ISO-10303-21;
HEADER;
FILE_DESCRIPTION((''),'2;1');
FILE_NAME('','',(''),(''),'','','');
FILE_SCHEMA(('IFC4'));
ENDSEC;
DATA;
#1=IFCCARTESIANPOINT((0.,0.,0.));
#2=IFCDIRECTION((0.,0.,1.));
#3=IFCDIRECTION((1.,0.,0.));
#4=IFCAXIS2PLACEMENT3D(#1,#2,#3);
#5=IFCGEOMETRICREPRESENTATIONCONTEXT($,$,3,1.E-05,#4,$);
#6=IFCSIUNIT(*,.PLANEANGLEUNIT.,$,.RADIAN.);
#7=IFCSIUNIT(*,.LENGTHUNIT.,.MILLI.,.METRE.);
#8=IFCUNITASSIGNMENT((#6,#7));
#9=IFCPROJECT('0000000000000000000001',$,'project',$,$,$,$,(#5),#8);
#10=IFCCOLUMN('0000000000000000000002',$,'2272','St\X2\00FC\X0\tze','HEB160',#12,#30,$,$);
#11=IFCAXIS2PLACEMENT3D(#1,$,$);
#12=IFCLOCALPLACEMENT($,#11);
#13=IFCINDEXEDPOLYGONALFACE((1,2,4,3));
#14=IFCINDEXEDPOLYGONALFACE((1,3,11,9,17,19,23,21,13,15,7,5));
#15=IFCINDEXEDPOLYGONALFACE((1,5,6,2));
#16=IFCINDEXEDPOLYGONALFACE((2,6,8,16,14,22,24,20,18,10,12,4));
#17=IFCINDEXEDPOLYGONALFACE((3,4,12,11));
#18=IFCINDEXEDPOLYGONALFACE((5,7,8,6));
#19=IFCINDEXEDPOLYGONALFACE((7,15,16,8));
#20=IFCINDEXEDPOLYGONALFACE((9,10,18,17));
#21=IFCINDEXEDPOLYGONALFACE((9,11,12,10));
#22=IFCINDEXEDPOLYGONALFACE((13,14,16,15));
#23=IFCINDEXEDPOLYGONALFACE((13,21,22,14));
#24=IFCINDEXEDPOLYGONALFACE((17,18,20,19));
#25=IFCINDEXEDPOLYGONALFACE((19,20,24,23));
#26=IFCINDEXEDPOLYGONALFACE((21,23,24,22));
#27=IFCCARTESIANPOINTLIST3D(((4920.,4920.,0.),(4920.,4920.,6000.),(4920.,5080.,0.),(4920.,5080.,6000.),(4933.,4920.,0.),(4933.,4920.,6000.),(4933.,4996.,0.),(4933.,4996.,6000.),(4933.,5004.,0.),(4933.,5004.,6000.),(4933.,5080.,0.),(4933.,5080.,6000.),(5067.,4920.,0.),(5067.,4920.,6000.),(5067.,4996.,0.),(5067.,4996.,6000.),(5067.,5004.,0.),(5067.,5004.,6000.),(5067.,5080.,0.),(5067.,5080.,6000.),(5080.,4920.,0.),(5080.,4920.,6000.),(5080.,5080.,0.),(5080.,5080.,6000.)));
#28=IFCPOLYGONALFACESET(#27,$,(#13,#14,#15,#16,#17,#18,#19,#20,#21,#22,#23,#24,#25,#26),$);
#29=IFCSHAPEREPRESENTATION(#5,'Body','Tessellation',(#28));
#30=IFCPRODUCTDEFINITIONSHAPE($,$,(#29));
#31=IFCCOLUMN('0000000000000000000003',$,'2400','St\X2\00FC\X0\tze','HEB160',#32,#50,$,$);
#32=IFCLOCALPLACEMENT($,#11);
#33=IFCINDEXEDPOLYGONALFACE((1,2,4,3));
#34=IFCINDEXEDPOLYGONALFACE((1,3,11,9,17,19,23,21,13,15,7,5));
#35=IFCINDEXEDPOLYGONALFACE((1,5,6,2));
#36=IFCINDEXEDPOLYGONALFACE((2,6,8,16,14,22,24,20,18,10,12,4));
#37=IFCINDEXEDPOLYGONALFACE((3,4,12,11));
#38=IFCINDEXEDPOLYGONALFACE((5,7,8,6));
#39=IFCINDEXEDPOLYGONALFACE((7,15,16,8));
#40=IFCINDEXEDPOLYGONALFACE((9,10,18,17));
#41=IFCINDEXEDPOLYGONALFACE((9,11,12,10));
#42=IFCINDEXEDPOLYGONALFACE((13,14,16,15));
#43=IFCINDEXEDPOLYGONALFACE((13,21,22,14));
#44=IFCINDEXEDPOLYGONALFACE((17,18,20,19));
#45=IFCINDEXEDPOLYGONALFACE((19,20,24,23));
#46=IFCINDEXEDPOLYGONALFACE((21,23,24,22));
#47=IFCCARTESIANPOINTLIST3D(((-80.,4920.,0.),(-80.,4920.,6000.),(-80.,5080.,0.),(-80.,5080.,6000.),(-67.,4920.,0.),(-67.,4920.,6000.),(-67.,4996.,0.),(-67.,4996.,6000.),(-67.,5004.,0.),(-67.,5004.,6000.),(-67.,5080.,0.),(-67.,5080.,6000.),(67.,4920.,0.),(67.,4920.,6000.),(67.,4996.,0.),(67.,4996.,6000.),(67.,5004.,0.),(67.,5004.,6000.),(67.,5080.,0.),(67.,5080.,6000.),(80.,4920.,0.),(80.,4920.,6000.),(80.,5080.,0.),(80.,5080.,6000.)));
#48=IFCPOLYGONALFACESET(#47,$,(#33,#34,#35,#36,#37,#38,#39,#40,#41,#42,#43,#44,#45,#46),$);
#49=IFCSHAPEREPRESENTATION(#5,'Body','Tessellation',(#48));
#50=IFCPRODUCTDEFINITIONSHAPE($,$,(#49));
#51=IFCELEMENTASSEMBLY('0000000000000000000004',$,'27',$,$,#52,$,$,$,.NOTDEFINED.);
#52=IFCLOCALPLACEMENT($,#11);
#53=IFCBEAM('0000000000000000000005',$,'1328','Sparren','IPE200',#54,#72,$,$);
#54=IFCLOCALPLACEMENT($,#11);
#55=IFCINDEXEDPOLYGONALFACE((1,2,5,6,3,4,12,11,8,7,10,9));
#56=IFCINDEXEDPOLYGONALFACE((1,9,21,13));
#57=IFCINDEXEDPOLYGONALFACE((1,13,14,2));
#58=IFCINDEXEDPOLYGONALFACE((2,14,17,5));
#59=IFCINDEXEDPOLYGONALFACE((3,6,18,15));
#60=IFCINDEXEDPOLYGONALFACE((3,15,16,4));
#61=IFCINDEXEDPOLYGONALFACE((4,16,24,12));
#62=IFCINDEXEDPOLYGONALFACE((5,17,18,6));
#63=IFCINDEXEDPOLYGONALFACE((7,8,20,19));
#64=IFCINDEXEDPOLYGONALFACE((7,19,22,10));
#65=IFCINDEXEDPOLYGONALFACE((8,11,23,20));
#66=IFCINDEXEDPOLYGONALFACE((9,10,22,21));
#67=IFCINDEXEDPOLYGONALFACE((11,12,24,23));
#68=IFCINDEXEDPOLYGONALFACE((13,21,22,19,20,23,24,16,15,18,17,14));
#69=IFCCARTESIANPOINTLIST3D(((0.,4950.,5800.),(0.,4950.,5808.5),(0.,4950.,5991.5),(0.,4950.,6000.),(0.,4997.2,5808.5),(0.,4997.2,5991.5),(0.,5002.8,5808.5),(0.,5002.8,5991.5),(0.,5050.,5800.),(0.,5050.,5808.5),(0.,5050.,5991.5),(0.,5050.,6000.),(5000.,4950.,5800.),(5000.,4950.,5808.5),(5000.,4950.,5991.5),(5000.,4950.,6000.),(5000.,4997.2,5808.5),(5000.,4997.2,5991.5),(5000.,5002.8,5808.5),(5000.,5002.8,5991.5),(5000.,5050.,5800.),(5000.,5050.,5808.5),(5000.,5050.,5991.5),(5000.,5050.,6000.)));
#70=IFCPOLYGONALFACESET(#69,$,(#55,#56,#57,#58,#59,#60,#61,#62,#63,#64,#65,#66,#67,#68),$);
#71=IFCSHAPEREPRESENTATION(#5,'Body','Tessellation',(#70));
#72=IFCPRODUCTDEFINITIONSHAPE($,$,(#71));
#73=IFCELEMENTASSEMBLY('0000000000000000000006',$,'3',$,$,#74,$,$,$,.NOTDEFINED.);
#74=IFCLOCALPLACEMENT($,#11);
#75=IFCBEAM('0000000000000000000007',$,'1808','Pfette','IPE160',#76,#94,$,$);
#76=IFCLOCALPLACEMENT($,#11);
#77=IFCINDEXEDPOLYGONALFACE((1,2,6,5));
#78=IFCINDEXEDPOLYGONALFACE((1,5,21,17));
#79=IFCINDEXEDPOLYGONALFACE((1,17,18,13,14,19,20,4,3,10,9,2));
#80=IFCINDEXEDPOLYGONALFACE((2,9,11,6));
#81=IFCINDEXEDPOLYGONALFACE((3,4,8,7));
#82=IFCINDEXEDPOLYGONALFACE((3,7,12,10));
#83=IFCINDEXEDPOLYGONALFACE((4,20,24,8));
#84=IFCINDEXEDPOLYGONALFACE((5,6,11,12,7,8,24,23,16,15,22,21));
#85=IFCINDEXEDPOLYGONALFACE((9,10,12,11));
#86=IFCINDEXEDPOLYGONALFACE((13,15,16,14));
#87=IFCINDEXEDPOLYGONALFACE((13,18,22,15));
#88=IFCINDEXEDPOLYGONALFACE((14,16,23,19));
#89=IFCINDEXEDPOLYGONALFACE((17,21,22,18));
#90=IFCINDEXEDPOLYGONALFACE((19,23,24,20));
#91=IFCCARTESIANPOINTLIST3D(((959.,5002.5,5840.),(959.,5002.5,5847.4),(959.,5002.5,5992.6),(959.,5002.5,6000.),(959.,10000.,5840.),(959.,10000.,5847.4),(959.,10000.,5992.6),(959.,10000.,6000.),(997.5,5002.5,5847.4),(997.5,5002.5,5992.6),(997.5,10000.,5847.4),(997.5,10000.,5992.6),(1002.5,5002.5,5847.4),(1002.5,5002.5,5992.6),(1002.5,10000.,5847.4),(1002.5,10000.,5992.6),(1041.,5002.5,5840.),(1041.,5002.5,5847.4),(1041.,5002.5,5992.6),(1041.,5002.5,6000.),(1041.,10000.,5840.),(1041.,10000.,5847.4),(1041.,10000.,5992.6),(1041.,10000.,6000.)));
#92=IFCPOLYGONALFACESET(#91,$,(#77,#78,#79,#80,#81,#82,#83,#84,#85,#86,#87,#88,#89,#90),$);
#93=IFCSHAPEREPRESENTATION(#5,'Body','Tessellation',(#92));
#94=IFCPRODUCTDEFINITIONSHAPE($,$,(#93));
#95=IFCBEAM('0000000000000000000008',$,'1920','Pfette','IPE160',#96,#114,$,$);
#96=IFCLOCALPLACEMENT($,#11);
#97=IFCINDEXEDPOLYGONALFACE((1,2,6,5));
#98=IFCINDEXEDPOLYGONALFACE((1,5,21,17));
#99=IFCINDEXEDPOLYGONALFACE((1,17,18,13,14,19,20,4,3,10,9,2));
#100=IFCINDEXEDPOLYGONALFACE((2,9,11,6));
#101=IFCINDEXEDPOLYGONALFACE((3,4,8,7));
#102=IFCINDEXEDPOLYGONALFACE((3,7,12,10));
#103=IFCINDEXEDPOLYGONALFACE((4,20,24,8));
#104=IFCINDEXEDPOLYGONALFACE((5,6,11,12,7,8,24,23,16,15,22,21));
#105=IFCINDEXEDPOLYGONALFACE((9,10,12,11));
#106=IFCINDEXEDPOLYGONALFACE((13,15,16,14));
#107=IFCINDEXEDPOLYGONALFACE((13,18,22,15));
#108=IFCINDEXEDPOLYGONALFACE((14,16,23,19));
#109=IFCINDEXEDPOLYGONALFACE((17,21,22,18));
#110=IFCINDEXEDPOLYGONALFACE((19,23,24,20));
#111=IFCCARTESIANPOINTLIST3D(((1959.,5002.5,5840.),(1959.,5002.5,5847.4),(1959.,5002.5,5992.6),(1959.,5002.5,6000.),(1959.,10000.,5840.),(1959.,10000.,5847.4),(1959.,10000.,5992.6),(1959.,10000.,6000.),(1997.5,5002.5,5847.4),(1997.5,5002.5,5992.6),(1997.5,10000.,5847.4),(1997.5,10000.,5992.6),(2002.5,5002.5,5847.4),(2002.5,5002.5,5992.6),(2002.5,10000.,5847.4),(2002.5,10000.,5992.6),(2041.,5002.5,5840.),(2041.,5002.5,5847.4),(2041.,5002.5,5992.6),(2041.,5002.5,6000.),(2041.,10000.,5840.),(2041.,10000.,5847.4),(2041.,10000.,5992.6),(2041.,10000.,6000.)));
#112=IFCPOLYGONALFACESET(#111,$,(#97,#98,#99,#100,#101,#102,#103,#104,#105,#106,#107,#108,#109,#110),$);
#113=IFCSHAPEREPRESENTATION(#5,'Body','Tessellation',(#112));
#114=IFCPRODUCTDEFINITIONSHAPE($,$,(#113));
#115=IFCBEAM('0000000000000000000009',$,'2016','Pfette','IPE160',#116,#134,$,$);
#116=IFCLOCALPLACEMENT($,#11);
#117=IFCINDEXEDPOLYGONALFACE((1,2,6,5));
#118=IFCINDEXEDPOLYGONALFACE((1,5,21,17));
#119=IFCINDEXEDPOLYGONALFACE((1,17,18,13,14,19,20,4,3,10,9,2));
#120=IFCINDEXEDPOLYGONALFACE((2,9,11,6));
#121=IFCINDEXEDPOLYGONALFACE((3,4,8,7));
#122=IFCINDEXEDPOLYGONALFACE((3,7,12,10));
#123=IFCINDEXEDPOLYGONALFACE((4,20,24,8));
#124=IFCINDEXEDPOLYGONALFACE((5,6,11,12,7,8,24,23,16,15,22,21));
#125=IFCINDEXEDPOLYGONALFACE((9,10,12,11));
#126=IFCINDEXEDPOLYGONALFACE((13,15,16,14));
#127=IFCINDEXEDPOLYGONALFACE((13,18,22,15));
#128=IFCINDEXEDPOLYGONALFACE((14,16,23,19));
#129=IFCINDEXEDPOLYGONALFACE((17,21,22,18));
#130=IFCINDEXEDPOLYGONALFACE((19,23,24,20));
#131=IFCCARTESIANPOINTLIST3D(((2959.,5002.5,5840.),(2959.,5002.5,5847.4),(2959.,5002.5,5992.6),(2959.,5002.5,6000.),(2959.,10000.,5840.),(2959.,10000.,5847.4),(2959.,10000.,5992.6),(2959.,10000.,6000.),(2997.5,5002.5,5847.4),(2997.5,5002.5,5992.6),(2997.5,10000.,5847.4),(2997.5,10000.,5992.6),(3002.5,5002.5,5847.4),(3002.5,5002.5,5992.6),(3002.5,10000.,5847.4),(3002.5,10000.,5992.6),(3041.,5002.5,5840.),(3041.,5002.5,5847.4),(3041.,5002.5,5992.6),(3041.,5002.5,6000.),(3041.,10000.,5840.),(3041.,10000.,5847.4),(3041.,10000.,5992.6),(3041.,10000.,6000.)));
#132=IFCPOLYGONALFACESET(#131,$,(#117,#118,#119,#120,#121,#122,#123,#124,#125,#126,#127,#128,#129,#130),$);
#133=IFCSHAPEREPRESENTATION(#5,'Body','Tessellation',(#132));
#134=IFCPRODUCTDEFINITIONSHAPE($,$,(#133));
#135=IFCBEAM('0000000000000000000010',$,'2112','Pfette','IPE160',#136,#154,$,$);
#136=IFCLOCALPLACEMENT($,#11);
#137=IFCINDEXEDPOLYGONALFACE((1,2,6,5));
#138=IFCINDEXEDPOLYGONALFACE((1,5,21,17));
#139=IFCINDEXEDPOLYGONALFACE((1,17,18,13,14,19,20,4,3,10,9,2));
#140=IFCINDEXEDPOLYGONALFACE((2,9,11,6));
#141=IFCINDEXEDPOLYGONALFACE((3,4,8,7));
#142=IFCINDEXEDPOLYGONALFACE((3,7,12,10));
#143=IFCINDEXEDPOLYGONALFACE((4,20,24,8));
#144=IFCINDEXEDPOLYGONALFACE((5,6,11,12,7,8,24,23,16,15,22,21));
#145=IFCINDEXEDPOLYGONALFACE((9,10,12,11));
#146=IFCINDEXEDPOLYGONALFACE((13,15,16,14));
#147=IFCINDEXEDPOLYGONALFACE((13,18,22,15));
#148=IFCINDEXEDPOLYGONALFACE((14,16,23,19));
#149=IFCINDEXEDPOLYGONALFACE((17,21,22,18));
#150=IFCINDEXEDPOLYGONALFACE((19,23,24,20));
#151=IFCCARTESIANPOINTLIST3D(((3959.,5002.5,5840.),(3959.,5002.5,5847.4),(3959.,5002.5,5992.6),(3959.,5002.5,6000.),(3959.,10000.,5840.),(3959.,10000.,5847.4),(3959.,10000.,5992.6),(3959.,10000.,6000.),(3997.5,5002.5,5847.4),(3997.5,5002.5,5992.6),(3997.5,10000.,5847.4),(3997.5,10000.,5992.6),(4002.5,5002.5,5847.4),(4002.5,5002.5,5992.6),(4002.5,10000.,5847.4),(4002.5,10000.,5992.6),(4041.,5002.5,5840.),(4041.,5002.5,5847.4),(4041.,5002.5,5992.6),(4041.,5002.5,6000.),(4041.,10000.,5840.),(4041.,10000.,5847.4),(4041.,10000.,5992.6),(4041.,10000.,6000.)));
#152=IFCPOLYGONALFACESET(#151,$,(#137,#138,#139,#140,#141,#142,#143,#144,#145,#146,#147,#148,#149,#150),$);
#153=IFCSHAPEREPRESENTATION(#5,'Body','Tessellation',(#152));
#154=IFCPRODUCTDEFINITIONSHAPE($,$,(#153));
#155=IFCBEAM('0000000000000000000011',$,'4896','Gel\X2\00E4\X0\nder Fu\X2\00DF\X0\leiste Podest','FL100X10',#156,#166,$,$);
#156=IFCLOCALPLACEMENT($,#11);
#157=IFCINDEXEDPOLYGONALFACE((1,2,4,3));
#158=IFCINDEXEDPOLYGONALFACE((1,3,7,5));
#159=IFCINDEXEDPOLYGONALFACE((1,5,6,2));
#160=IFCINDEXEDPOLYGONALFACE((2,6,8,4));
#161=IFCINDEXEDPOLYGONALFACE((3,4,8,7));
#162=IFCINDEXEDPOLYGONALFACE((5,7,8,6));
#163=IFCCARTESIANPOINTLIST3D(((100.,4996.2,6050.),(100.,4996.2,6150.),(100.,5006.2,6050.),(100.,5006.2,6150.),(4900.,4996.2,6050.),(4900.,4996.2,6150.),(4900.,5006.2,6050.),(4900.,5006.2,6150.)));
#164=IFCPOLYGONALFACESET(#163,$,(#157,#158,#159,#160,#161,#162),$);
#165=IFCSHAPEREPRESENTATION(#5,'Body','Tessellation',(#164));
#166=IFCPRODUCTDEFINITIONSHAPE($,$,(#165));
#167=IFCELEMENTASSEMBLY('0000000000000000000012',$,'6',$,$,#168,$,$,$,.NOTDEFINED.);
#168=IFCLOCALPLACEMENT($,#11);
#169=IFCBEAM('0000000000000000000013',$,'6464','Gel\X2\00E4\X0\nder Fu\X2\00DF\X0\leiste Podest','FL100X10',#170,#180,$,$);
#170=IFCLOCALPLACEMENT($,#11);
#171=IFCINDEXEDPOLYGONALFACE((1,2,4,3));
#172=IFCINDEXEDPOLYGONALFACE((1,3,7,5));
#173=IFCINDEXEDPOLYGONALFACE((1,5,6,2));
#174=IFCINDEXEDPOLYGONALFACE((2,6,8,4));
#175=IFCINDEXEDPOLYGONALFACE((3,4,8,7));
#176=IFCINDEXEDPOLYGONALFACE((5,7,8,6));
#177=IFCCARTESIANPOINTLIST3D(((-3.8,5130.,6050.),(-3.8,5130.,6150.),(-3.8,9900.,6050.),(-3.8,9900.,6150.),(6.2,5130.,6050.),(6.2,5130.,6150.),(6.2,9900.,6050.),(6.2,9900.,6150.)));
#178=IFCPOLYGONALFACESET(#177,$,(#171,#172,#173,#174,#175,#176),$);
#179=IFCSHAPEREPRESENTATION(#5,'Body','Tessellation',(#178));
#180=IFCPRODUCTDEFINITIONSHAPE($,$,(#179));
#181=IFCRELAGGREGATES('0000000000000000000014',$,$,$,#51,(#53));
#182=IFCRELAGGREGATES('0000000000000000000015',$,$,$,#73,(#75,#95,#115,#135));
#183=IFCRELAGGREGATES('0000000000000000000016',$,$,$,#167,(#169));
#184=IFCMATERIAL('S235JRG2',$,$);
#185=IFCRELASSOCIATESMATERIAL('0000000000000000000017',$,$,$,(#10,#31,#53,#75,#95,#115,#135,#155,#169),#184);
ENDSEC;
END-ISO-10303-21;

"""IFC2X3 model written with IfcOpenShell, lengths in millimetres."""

from ifc_helpers import new_model, si_unit, frame, origin_with_axes, place, context, project, polyline, outline, extrude, material, element, aggregate, save


model = new_model("IFC2X3")

# Units and contexts
context_of_model = context(None, 3, precision=1e-05, world=origin_with_axes())
ifc_project = project(units=[si_unit("PLANEANGLEUNIT", "RADIAN"), si_unit("LENGTHUNIT", "METRE", prefix="MILLI")], contexts=[context_of_model])

# Columns
ifc_material = material(Name="S235JRG2")
placement_1 = place(None, frame((5000.0, 5000.0, 6000.0), z_axis=(1.0, 0.0, 0.0), x_axis=(0.0, 0.0, -1.0)))
column_1_placement = place(placement_1, origin_with_axes())
element("IfcColumn", 1, at=column_1_placement, material=ifc_material, Name="2272", Description="Stütze", ObjectType="HEB160", context=context_of_model, shape_type="SweptSolid", body=[
    extrude(outline(polyline([(80.0, -80.0), (80.0, -67.0), (4.0, -67.0), (4.0, 67.0), (80.0, 67.0), (80.0, 80.0), (-80.0, 80.0), (-80.0, 67.0), (-4.0, 67.0), (-4.0, -67.0), (-80.0, -67.0), (-80.0, -80.0), (80.0, -80.0), (80.0, -80.0)])), frame((0.0, 0.0, 0.0), z_axis=(1.0, 0.0, 0.0), x_axis=(0.0, 1.0, 0.0)), (0.0, 0.0, 1.0), 6000.0),
])
placement_2 = place(None, frame((0.0, 5000.0, 6000.0), z_axis=(-1.0, 0.0, 0.0), x_axis=(0.0, 0.0, -1.0)))
column_2_placement = place(placement_2, origin_with_axes())
element("IfcColumn", 2, at=column_2_placement, material=ifc_material, Name="2400", Description="Stütze", ObjectType="HEB160", context=context_of_model, shape_type="SweptSolid", body=[
    extrude(outline(polyline([(80.0, -80.0), (80.0, -67.0), (4.0, -67.0), (4.0, 67.0), (80.0, 67.0), (80.0, 80.0), (-80.0, 80.0), (-80.0, 67.0), (-4.0, 67.0), (-4.0, -67.0), (-80.0, -67.0), (-80.0, -80.0), (80.0, -80.0), (80.0, -80.0)])), frame((0.0, 0.0, 0.0), z_axis=(1.0, 0.0, 0.0), x_axis=(0.0, 1.0, 0.0)), (0.0, 0.0, 1.0), 6000.0),
])

# Element assembly, beam
assembly_1_placement = place(None, frame((5000.0, 5000.0, 6000.0), z_axis=(0.0, 0.0, 1.0), x_axis=(-1.0, 0.0, 0.0)))
assembly_1 = element("IfcElementAssembly", 3, at=assembly_1_placement, Name="27", PredefinedType="NOTDEFINED")
placement_3 = place(None, frame((5000.0, 5000.0, 5900.0), z_axis=(0.0, 0.0, 1.0), x_axis=(-1.0, 0.0, 0.0)))
beam_1_placement = place(placement_3, origin_with_axes())
beam_1 = element("IfcBeam", 4, at=beam_1_placement, material=ifc_material, Name="1328", Description="Sparren", ObjectType="IPE200", context=context_of_model, shape_type="SweptSolid", body=[
    extrude(outline(polyline([(50.0, -100.0), (50.0, -91.5), (2.8, -91.5), (2.8, 91.5), (50.0, 91.5), (50.0, 100.0), (-50.0, 100.0), (-50.0, 91.5), (-2.8, 91.5), (-2.8, -91.5), (-50.0, -91.5), (-50.0, -100.0), (50.0, -100.0), (50.0, -100.0)])), frame((0.0, 0.0, 0.0), z_axis=(1.0, 0.0, 0.0), x_axis=(0.0, 1.0, 0.0)), (0.0, 0.0, 1.0), 5000.0),
])
aggregate(assembly_1, [beam_1])

# Element assembly, beams
assembly_2_placement = place(None, frame((1000.0, 5002.5, 6000.0), z_axis=(0.0, 0.0, 1.0), x_axis=(0.0, 1.0, 0.0)))
assembly_2 = element("IfcElementAssembly", 5, at=assembly_2_placement, Name="3", PredefinedType="NOTDEFINED")
placement_4 = place(None, frame((1000.0, 5002.5, 5920.0), z_axis=(0.0, 0.0, 1.0), x_axis=(0.0, 1.0, 0.0)))
beam_2_placement = place(placement_4, origin_with_axes())
beam_2 = element("IfcBeam", 6, at=beam_2_placement, material=ifc_material, Name="1808", Description="Pfette", ObjectType="IPE160", context=context_of_model, shape_type="SweptSolid", body=[
    extrude(outline(polyline([(41.0, -80.0), (41.0, -72.6), (2.5, -72.6), (2.5, 72.6), (41.0, 72.6), (41.0, 80.0), (-41.0, 80.0), (-41.0, 72.6), (-2.5, 72.6), (-2.5, -72.6), (-41.0, -72.6), (-41.0, -80.0), (41.0, -80.0), (41.0, -80.0)])), frame((0.0, 0.0, 0.0), z_axis=(1.0, 0.0, 0.0), x_axis=(0.0, 1.0, 0.0)), (0.0, 0.0, 1.0), 4997.5),
])
placement_5 = place(None, frame((2000.0, 5002.5, 5920.0), z_axis=(0.0, 0.0, 1.0), x_axis=(0.0, 1.0, 0.0)))
beam_3_placement = place(placement_5, origin_with_axes())
beam_3 = element("IfcBeam", 7, at=beam_3_placement, material=ifc_material, Name="1920", Description="Pfette", ObjectType="IPE160", context=context_of_model, shape_type="SweptSolid", body=[
    extrude(outline(polyline([(41.0, -80.0), (41.0, -72.6), (2.5, -72.6), (2.5, 72.6), (41.0, 72.6), (41.0, 80.0), (-41.0, 80.0), (-41.0, 72.6), (-2.5, 72.6), (-2.5, -72.6), (-41.0, -72.6), (-41.0, -80.0), (41.0, -80.0), (41.0, -80.0)])), frame((0.0, 0.0, 0.0), z_axis=(1.0, 0.0, 0.0), x_axis=(0.0, 1.0, 0.0)), (0.0, 0.0, 1.0), 4997.5),
])
placement_6 = place(None, frame((3000.0, 5002.5, 5920.0), z_axis=(0.0, 0.0, 1.0), x_axis=(0.0, 1.0, 0.0)))
beam_4_placement = place(placement_6, origin_with_axes())
beam_4 = element("IfcBeam", 8, at=beam_4_placement, material=ifc_material, Name="2016", Description="Pfette", ObjectType="IPE160", context=context_of_model, shape_type="SweptSolid", body=[
    extrude(outline(polyline([(41.0, -80.0), (41.0, -72.6), (2.5, -72.6), (2.5, 72.6), (41.0, 72.6), (41.0, 80.0), (-41.0, 80.0), (-41.0, 72.6), (-2.5, 72.6), (-2.5, -72.6), (-41.0, -72.6), (-41.0, -80.0), (41.0, -80.0), (41.0, -80.0)])), frame((0.0, 0.0, 0.0), z_axis=(1.0, 0.0, 0.0), x_axis=(0.0, 1.0, 0.0)), (0.0, 0.0, 1.0), 4997.5),
])
placement_7 = place(None, frame((4000.0, 5002.5, 5920.0), z_axis=(0.0, 0.0, 1.0), x_axis=(0.0, 1.0, 0.0)))
beam_5_placement = place(placement_7, origin_with_axes())
beam_5 = element("IfcBeam", 9, at=beam_5_placement, material=ifc_material, Name="2112", Description="Pfette", ObjectType="IPE160", context=context_of_model, shape_type="SweptSolid", body=[
    extrude(outline(polyline([(41.0, -80.0), (41.0, -72.6), (2.5, -72.6), (2.5, 72.6), (41.0, 72.6), (41.0, 80.0), (-41.0, 80.0), (-41.0, 72.6), (-2.5, 72.6), (-2.5, -72.6), (-41.0, -72.6), (-41.0, -80.0), (41.0, -80.0), (41.0, -80.0)])), frame((0.0, 0.0, 0.0), z_axis=(1.0, 0.0, 0.0), x_axis=(0.0, 1.0, 0.0)), (0.0, 0.0, 1.0), 4997.5),
])
aggregate(assembly_2, [beam_2, beam_3, beam_4, beam_5])

# Beam
placement_8 = place(None, frame((4900.0, 5001.2, 6100.0), z_axis=(0.0, 0.0, 1.0), x_axis=(-1.0, 0.0, 0.0)))
beam_6_placement = place(placement_8, origin_with_axes())
element("IfcBeam", 10, at=beam_6_placement, material=ifc_material, Name="4896", Description="Geländer Fußleiste Podest", ObjectType="FL100X10", context=context_of_model, shape_type="SweptSolid", body=[
    extrude(outline(polyline([(5.0, -50.0), (5.0, 50.0), (-5.0, 50.0), (-5.0, -50.0), (5.0, -50.0), (5.0, -50.0)])), frame((0.0, 0.0, 0.0), z_axis=(1.0, 0.0, 0.0), x_axis=(0.0, 1.0, 0.0)), (0.0, 0.0, 1.0), 4800.0),
])

# Element assembly, beam
assembly_3_placement = place(None, frame((1.2, 5130.0, 6100.0), z_axis=(0.0, 0.0, 1.0), x_axis=(0.0, 1.0, 0.0)))
assembly_3 = element("IfcElementAssembly", 11, at=assembly_3_placement, Name="6", PredefinedType="NOTDEFINED")
placement_9 = place(None, frame((1.2, 5130.0, 6100.0), z_axis=(0.0, 0.0, 1.0), x_axis=(0.0, 1.0, 0.0)))
beam_7_placement = place(placement_9, origin_with_axes())
beam_7 = element("IfcBeam", 12, at=beam_7_placement, material=ifc_material, Name="6464", Description="Geländer Fußleiste Podest", ObjectType="FL100X10", context=context_of_model, shape_type="SweptSolid", body=[
    extrude(outline(polyline([(5.0, -50.0), (5.0, 50.0), (-5.0, 50.0), (-5.0, -50.0), (5.0, -50.0), (5.0, -50.0)])), frame((0.0, 0.0, 0.0), z_axis=(1.0, 0.0, 0.0), x_axis=(0.0, 1.0, 0.0)), (0.0, 0.0, 1.0), 4770.0),
])
aggregate(assembly_3, [beam_7])

save(model, "model.ifc")
